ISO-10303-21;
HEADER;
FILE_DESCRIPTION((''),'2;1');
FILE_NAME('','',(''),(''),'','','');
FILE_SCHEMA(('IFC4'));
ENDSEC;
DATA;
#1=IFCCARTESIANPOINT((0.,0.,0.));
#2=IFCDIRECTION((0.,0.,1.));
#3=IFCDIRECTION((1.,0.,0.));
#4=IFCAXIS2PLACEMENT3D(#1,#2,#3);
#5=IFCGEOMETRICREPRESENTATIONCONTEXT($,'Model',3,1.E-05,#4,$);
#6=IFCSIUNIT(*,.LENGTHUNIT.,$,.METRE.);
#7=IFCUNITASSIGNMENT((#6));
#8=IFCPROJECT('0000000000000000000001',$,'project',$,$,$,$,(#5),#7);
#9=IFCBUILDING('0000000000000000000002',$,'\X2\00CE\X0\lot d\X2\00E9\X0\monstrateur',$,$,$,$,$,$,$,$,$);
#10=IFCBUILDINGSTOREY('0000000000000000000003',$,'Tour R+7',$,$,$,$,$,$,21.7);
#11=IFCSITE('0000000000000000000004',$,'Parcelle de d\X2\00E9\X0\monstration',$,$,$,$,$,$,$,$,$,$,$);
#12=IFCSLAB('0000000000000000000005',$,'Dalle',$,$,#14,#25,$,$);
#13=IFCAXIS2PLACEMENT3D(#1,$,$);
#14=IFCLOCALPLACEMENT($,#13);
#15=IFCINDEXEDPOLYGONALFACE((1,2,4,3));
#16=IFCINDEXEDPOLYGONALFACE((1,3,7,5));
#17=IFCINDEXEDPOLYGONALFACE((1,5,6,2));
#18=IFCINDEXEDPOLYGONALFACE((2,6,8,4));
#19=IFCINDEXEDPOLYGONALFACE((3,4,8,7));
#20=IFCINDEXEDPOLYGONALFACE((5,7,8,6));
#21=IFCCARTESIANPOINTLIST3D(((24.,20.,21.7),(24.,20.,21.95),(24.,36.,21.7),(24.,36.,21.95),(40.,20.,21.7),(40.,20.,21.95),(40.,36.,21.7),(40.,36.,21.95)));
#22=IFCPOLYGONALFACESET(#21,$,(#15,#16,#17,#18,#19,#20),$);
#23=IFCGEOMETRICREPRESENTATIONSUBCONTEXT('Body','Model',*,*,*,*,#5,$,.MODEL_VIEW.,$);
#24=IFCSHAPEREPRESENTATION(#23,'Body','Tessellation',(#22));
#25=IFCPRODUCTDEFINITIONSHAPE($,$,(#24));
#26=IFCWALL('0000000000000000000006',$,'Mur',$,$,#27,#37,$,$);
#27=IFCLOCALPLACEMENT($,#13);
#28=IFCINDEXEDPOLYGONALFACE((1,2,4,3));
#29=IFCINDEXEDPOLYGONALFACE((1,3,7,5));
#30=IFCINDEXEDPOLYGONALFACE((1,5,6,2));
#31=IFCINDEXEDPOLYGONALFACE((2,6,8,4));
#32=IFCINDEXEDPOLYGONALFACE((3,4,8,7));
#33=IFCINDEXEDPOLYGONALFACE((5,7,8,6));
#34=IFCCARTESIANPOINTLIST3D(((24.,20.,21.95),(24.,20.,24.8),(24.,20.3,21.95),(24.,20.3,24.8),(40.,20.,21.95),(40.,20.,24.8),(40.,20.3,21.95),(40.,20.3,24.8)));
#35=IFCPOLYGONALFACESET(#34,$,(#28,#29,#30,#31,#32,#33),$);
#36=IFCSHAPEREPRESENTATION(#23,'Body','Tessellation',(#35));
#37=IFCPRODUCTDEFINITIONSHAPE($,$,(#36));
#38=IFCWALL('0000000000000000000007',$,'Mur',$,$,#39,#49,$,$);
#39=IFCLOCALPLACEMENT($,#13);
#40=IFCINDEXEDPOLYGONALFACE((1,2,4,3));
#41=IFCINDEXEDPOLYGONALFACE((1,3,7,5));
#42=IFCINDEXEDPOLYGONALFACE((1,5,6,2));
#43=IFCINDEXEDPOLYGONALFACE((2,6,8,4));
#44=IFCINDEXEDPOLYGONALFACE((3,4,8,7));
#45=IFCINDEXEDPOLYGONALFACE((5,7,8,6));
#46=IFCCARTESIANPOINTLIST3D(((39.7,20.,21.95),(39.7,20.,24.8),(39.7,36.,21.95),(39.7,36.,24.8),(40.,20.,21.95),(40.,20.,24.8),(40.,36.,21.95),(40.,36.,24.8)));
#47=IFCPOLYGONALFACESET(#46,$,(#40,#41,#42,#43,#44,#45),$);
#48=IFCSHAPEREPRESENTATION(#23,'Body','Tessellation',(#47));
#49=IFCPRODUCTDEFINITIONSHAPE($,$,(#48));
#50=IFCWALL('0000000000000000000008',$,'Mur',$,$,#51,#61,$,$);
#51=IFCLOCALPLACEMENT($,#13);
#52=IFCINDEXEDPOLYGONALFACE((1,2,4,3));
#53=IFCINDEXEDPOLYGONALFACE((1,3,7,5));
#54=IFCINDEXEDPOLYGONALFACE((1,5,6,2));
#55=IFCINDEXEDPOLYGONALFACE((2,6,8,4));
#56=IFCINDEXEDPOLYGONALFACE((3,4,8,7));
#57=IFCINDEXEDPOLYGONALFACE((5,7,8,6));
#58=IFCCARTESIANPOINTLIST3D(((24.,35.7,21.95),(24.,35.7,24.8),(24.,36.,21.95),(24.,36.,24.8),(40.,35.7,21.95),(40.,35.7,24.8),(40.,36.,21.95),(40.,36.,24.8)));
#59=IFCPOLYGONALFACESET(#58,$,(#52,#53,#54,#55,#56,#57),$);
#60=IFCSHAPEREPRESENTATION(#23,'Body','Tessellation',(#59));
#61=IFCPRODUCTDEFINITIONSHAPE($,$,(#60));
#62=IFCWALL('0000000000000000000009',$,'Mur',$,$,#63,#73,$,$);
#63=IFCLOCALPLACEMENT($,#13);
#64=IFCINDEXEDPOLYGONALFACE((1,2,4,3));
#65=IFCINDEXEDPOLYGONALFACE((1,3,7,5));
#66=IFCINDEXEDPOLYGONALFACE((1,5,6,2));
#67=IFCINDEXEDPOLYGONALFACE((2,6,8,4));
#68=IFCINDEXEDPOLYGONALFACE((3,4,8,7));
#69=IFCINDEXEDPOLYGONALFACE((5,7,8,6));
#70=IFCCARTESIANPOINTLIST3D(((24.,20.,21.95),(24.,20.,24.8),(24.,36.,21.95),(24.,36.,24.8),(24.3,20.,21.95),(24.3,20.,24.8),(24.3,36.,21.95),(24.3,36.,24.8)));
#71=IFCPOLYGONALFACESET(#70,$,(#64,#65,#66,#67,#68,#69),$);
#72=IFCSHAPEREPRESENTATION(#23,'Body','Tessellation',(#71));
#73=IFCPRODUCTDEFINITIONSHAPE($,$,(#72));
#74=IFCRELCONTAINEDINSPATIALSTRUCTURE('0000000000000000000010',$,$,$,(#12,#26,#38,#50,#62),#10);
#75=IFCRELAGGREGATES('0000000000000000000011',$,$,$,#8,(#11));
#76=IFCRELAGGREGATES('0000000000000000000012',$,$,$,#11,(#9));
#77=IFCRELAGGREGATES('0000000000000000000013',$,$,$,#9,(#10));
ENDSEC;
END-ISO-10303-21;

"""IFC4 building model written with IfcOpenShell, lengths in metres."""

from ifc_helpers import new_model, si_unit, frame, origin_with_axes, place, context, subcontext, project, spatial, indexed_curve, outline, extrude, element, save


model = new_model("IFC4")

# Units and contexts
model_context = context("Model", 3, precision=1e-05, world=origin_with_axes())
body_context = subcontext(model_context, "Body", "Model", "MODEL_VIEW")
ifc_project = project(units=[si_unit("LENGTHUNIT", "METRE")], contexts=[model_context])

# Site, building, storey
site = spatial("IfcSite", under=ifc_project, Name="Parcelle de démonstration")
building = spatial("IfcBuilding", under=site, Name="Îlot démonstrateur")
storey = spatial("IfcBuildingStorey", under=building, Name="Tour R+7", Elevation=21.7)

# Slab
slab_placement = place(None, frame((0.0, 0.0, 21.7), z_axis=(0.0, 0.0, 1.0), x_axis=(1.0, 0.0, 0.0)))
element("IfcSlab", 1, at=slab_placement, inside=storey, Name="Dalle", context=body_context, shape_type="SweptSolid", body=[
    extrude(outline(indexed_curve([(24.0, 20.0), (40.0, 20.0), (40.0, 36.0), (24.0, 36.0)])), None, (0.0, 0.0, 1.0), 0.25),
])

# Walls
for number, where, z_axis, x_axis, name in (
    (2, (24.0, 20.0, 21.95), (0.0, 0.0, 1.0), (1.0, 0.0, 0.0), "Mur"),
    (3, (40.0, 20.0, 21.95), (0.0, 0.0, 1.0), (0.0, 1.0, 0.0), "Mur"),
    (4, (40.0, 36.0, 21.95), (0.0, 0.0, 1.0), (-1.0, 0.0, 0.0), "Mur"),
    (5, (24.0, 36.0, 21.95), (0.0, 0.0, 1.0), (0.0, -1.0, 0.0), "Mur"),
):
    element("IfcWall", number, at=place(None, frame(where, z_axis=z_axis, x_axis=x_axis)), inside=storey, Name=name, context=body_context, shape_type="SweptSolid", body=[
        extrude(outline(indexed_curve([(0.0, 0.0), (0.0, 0.3), (16.0, 0.3), (16.0, 0.0), (0.0, 0.0)], self_intersect=False)), origin_with_axes(), (0.0, 0.0, 1.0), 2.85),
    ])

save(model, "model.ifc")
